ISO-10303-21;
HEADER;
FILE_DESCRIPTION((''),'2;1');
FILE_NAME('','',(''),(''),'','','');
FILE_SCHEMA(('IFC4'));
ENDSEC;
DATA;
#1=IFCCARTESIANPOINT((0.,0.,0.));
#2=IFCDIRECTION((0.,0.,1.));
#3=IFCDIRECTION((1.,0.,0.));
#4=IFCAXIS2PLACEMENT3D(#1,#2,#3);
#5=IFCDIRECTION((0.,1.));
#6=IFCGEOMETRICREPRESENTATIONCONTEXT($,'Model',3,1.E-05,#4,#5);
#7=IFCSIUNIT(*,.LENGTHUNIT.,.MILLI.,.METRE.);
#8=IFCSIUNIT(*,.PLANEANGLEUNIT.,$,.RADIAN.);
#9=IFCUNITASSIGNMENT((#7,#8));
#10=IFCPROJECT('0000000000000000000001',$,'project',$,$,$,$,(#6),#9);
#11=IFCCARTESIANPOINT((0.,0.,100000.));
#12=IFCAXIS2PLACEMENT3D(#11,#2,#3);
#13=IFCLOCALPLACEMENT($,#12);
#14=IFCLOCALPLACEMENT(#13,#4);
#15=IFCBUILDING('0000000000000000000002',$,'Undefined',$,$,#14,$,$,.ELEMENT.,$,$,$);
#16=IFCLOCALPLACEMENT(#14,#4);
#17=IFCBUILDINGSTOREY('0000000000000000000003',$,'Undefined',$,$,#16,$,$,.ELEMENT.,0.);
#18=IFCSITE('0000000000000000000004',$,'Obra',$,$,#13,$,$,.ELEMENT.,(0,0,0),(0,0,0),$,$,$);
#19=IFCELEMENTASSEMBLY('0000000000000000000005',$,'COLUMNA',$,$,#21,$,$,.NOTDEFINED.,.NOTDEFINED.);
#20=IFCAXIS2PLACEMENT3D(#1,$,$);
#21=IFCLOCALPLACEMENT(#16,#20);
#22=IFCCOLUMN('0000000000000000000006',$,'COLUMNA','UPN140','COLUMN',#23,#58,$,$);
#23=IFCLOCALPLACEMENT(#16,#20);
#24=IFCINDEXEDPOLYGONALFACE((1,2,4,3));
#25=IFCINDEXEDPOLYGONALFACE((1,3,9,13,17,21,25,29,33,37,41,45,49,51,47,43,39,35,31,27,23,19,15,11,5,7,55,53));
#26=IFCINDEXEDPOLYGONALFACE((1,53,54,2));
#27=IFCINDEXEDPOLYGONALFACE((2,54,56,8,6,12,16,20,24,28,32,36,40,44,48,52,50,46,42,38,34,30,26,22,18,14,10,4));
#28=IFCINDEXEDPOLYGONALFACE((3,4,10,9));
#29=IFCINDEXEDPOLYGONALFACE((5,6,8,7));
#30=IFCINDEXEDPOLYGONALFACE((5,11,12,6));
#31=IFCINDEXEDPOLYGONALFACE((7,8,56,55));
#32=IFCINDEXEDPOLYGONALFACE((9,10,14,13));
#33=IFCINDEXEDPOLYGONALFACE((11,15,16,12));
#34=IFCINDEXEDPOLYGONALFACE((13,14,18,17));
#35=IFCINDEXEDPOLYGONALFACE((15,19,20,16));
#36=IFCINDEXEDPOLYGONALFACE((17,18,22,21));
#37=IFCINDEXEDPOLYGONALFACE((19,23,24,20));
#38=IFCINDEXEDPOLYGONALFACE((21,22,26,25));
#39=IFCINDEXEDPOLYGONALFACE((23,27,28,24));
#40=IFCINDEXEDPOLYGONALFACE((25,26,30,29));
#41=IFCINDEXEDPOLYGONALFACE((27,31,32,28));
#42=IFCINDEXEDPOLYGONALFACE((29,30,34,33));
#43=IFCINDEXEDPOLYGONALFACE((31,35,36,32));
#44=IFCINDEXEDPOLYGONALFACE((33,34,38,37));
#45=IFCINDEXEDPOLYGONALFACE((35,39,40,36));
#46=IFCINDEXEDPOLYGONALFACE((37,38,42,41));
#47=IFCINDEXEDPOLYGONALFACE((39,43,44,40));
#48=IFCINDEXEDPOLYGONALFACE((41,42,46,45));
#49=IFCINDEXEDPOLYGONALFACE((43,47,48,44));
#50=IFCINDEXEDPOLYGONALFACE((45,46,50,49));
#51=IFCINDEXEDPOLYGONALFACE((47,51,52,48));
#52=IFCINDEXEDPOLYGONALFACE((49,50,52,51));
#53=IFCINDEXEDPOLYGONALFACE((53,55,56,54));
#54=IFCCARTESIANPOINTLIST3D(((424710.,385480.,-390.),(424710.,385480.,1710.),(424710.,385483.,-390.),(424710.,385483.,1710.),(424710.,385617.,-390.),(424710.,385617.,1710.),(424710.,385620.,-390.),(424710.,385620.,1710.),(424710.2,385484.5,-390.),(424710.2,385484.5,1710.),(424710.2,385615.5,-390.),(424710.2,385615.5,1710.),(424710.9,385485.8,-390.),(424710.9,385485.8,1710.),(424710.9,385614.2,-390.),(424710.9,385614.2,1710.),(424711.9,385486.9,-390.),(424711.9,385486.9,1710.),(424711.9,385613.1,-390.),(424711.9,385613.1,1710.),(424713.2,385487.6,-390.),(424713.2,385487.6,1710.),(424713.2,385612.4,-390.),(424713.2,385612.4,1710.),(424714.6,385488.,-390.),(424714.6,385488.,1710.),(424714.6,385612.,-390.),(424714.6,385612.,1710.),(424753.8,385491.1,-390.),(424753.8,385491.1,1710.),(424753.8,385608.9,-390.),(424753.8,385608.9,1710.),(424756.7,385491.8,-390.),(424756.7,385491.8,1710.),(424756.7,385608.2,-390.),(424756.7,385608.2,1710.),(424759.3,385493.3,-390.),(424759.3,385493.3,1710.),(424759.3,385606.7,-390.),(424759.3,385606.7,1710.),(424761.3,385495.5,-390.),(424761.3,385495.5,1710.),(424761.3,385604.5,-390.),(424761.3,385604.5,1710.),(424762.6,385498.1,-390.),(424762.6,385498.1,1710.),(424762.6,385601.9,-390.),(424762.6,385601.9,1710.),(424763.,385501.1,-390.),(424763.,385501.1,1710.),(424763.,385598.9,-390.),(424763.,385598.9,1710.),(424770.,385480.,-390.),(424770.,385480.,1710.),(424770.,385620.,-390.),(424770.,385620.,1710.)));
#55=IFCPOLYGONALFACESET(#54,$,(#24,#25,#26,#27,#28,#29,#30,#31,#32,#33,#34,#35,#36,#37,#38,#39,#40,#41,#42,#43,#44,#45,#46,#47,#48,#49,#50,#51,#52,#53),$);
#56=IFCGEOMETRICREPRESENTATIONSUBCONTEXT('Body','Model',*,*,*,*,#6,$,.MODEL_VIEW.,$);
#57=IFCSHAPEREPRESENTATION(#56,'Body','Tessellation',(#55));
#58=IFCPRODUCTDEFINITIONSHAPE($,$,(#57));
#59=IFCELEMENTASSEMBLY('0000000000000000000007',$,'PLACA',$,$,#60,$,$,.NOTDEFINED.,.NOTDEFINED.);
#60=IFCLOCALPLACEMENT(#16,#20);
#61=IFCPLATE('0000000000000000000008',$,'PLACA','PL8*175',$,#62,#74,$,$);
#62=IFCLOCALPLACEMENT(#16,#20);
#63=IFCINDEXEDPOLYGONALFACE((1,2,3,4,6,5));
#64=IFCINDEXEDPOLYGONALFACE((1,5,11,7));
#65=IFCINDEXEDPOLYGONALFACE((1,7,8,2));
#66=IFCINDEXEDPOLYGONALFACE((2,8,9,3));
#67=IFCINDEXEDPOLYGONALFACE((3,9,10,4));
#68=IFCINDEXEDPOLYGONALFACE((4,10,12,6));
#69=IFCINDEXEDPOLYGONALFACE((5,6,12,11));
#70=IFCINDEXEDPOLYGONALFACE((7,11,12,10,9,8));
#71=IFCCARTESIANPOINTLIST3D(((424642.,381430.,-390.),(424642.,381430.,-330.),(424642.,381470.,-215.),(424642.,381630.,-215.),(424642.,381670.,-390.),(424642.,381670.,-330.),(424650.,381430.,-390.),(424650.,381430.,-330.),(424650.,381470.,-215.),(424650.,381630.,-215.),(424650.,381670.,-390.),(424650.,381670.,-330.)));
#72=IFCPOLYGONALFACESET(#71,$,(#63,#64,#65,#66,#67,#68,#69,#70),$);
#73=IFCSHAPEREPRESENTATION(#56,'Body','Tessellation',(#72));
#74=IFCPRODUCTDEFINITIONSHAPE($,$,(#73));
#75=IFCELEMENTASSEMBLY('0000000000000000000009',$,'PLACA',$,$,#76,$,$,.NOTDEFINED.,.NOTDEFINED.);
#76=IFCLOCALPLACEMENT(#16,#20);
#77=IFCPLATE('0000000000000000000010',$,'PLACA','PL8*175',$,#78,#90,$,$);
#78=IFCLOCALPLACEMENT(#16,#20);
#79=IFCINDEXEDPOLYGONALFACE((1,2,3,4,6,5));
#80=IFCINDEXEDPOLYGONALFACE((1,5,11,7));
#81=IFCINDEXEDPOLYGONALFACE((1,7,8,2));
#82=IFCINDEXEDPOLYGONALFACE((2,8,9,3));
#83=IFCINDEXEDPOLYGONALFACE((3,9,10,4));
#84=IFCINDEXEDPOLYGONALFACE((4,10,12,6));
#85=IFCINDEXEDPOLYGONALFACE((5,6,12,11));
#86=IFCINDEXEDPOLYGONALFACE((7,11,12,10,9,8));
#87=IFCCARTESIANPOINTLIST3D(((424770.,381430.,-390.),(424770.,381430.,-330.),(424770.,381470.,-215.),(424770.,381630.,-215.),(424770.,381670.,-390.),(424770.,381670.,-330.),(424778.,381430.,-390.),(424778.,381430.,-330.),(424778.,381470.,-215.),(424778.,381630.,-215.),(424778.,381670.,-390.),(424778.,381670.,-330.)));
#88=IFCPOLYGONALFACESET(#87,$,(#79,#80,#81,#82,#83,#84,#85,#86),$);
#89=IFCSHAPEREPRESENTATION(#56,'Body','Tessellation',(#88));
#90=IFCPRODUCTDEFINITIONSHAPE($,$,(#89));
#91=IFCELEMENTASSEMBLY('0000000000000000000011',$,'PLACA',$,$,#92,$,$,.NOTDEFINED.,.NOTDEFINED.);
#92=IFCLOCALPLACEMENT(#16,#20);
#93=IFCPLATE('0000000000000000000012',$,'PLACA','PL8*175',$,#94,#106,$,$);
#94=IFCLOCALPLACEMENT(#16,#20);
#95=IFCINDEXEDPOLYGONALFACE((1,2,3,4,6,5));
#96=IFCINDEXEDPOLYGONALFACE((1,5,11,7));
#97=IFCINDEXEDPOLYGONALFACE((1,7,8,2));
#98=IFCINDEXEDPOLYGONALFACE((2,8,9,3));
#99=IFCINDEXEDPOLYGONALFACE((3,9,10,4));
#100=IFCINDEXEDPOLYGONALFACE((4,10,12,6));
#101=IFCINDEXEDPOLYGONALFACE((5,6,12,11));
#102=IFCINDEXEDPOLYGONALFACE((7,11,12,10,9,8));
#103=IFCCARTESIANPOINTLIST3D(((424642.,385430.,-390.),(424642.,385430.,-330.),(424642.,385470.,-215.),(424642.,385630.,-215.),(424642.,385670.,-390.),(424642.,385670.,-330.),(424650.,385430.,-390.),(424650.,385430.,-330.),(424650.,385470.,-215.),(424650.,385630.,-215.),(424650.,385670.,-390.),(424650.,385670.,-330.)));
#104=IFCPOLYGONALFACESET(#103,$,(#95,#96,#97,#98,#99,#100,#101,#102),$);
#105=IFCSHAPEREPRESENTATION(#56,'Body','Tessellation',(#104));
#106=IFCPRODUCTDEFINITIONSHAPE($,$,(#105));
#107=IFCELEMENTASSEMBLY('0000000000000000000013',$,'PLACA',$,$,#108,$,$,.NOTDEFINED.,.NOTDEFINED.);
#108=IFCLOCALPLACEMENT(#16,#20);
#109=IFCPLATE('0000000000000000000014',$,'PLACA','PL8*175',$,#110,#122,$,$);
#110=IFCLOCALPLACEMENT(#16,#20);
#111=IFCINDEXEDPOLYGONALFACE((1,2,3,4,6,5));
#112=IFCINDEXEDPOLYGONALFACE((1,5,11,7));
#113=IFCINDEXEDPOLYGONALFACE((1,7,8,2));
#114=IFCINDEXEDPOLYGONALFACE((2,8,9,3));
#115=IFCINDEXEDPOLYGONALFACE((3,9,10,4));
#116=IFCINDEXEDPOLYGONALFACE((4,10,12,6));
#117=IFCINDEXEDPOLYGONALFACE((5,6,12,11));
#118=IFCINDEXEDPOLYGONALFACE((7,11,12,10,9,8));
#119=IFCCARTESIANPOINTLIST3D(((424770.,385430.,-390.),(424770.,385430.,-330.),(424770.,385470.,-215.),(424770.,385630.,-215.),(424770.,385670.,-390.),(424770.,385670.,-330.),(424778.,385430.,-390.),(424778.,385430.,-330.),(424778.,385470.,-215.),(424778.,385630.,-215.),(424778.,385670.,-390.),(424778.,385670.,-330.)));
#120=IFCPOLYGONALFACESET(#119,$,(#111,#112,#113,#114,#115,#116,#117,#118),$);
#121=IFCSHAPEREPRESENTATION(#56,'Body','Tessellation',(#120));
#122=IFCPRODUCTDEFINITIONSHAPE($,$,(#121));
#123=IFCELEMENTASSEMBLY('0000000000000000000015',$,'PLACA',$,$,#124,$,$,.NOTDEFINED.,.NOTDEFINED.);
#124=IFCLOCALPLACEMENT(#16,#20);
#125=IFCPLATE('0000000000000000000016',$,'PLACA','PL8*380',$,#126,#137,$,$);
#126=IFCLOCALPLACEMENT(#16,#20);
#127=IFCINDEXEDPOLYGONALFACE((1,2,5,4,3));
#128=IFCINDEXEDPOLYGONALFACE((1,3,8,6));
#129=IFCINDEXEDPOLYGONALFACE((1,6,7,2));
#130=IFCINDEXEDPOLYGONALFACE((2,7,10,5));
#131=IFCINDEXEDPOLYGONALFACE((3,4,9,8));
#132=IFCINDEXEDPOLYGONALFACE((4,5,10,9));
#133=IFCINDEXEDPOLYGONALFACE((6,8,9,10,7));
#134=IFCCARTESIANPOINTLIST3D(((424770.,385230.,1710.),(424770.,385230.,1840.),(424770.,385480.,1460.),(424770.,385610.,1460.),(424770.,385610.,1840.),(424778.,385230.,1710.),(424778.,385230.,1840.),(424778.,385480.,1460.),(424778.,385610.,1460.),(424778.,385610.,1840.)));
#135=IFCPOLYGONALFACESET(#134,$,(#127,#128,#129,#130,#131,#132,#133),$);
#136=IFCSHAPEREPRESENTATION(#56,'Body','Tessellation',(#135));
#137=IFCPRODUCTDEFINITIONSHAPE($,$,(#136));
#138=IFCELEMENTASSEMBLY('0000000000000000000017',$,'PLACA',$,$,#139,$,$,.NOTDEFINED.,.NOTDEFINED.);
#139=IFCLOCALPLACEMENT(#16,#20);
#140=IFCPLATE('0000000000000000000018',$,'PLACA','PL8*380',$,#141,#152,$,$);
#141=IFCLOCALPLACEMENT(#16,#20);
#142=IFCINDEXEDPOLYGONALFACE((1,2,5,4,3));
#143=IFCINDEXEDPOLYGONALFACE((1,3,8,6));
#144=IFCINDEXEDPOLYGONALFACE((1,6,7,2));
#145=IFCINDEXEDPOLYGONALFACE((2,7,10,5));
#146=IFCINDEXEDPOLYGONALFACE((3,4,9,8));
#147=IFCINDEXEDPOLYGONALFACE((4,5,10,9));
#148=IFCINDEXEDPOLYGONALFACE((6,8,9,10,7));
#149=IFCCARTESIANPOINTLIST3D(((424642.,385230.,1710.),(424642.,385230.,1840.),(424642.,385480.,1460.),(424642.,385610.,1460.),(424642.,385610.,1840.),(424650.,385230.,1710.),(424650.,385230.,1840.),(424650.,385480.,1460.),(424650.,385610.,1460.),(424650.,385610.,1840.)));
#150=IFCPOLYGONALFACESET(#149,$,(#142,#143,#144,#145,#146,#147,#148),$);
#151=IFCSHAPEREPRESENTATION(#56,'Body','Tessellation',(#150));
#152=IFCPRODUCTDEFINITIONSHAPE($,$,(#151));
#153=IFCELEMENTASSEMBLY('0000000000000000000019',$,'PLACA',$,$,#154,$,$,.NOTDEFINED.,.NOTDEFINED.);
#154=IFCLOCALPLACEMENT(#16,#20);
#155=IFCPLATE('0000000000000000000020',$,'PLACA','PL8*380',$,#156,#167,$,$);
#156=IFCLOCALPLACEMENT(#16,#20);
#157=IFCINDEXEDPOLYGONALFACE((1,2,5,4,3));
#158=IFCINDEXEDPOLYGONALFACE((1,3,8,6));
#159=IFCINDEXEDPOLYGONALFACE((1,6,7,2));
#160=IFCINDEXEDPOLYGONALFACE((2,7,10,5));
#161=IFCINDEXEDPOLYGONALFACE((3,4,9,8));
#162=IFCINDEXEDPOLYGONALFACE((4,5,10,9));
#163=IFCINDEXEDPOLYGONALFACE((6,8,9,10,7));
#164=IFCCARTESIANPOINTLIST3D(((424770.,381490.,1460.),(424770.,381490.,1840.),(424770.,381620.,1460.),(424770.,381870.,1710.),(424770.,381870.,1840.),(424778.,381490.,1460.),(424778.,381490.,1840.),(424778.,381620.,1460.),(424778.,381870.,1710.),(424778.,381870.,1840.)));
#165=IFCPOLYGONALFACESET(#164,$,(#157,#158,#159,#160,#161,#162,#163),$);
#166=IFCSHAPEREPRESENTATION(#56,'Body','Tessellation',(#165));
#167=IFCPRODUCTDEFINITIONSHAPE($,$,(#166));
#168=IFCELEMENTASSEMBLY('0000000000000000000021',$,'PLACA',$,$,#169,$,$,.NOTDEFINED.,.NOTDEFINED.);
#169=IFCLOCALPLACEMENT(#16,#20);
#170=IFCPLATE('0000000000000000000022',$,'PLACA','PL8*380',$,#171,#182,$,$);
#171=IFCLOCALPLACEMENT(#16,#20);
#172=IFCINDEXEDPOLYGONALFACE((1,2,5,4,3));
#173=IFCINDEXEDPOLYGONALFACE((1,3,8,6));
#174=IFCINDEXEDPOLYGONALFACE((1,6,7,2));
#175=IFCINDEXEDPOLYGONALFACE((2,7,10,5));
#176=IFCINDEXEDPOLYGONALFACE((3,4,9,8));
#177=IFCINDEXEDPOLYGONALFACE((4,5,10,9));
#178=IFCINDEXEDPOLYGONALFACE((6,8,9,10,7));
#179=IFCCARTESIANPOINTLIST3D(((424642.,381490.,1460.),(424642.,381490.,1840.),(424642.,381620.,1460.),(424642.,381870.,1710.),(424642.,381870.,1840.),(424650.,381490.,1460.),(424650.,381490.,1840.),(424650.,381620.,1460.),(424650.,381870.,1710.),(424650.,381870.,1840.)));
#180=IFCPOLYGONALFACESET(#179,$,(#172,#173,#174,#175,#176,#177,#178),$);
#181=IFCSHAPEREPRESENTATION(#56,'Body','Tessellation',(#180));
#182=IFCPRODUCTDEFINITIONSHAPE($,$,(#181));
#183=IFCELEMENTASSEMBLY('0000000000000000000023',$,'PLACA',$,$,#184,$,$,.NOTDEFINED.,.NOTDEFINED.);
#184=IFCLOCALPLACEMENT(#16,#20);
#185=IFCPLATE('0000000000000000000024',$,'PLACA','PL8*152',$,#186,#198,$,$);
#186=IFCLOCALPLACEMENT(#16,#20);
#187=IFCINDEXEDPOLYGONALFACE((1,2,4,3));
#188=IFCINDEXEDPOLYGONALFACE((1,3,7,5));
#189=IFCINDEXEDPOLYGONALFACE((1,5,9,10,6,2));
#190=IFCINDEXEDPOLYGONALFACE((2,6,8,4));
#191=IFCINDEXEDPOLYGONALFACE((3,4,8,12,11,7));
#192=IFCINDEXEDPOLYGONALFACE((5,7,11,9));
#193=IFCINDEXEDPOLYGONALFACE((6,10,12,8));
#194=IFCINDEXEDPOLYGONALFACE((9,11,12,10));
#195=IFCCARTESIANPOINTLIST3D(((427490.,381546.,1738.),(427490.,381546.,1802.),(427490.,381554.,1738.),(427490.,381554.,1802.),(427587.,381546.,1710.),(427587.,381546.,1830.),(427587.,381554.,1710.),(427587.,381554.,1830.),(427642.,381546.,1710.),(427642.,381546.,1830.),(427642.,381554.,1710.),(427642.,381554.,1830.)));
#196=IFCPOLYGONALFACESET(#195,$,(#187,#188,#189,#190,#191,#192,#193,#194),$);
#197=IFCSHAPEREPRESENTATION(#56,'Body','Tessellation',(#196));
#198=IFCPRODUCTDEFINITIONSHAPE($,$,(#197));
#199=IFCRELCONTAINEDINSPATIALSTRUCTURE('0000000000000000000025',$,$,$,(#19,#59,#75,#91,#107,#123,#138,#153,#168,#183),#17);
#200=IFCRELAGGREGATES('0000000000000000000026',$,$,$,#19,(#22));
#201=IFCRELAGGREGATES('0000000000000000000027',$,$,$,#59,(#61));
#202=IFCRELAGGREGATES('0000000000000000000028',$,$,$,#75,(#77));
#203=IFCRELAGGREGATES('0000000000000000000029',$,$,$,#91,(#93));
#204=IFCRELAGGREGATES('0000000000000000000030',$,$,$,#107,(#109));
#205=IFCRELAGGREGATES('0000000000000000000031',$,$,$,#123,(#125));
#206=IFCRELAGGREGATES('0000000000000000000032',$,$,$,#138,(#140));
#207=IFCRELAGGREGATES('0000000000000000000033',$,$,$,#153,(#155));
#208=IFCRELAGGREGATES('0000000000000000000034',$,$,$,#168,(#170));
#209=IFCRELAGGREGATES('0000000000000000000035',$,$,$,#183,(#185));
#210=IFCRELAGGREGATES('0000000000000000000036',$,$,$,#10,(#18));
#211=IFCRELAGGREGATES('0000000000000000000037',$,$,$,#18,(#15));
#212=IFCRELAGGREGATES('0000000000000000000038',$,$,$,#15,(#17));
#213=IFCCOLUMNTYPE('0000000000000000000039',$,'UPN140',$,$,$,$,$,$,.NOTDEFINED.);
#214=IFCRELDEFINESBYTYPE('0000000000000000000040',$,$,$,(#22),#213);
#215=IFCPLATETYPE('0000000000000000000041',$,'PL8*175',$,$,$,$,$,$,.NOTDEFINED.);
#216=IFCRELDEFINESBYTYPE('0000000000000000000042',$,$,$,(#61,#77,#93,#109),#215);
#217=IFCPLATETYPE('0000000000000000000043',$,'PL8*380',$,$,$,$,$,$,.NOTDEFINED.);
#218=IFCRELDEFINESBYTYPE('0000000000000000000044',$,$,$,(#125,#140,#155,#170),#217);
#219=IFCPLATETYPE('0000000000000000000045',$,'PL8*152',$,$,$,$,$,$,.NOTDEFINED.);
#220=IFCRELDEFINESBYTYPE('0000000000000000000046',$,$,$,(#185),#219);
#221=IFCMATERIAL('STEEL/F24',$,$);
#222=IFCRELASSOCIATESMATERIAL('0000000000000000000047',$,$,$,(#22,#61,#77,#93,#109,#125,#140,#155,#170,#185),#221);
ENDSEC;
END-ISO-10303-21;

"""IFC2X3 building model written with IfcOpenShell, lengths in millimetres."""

from ifc_helpers import new_model, si_unit, direction, frame, origin_with_axes, origin_2d_with_axis, place, context, subcontext, project, spatial, polyline, u_section, outline, extrude, material, type_object, element, aggregate, save


model = new_model("IFC2X3")

# Units and contexts
model_context = context("Model", 3, precision=1e-05, world=origin_with_axes(), true_north=direction((0.0, 1.0)))
body_context = subcontext(model_context, "Body", "Model", "MODEL_VIEW")
ifc_project = project(units=[si_unit("LENGTHUNIT", "METRE", prefix="MILLI"), si_unit("PLANEANGLEUNIT", "RADIAN")], contexts=[model_context])

# Site, building, storey
site_placement = place(None, frame((0.0, 0.0, 100000.0), z_axis=(0.0, 0.0, 1.0), x_axis=(1.0, 0.0, 0.0)))
site = spatial("IfcSite", under=ifc_project, at=site_placement, Name="Obra", CompositionType="ELEMENT", RefLatitude=(0, 0, 0), RefLongitude=(0, 0, 0))
building_placement = place(site_placement, origin_with_axes())
building = spatial("IfcBuilding", under=site, at=building_placement, Name="Undefined", CompositionType="ELEMENT")
storey_placement = place(building_placement, origin_with_axes())
storey = spatial("IfcBuildingStorey", under=building, at=storey_placement, Name="Undefined", CompositionType="ELEMENT", Elevation=0.0)

# Element assembly, column
ifc_material_1 = material(Name="STEEL/F24")
column_type_1 = type_object("IfcColumnType", Name="UPN140", PredefinedType="NOTDEFINED")
assembly_1_placement = place(storey_placement, origin_with_axes())
assembly_1 = element("IfcElementAssembly", 1, at=assembly_1_placement, inside=storey, Name="COLUMNA", AssemblyPlace="NOTDEFINED", PredefinedType="NOTDEFINED")
column_1_placement = place(assembly_1_placement, frame((424740.0, 385550.0, -390.0), z_axis=(0.0, 0.0, 1.0), x_axis=(0.0, 1.0, 0.0)))
column_1 = element("IfcColumn", 2, at=column_1_placement, type_object=column_type_1, material=ifc_material_1, Name="COLUMNA", Description="UPN140", ObjectType="COLUMN", context=body_context, shape_type="SweptSolid", body=[
    extrude(u_section(Depth=140.0, FlangeWidth=60.0, WebThickness=7.0, FlangeThickness=10.0, FilletRadius=10.0, EdgeRadius=5.0, FlangeSlope=0.07983, at=origin_2d_with_axis()), frame((0.0, 0.0, 2100.0), z_axis=(0.0, 0.0, -1.0), x_axis=(0.0, 1.0, 0.0)), (0.0, 0.0, 1.0), 2100.0),
])
aggregate(assembly_1, [column_1])

# Element assemblies, plates
assembly_2_placement = place(storey_placement, origin_with_axes())
assembly_2 = element("IfcElementAssembly", 3, at=assembly_2_placement, inside=storey, Name="PLACA", AssemblyPlace="NOTDEFINED", PredefinedType="NOTDEFINED")
plate_type_1 = type_object("IfcPlateType", Name="PL8*175", PredefinedType="NOTDEFINED")
plate_1_placement = place(assembly_2_placement, frame((424646.0, 381630.0, -215.0), z_axis=(-1.0, 0.0, 0.0), x_axis=(0.0, 0.328521, -0.944497)))
plate_1 = element("IfcPlate", 4, at=plate_1_placement, type_object=plate_type_1, material=ifc_material_1, Name="PLACA", Description="PL8*175", context=body_context, shape_type="SweptSolid", body=[
    extrude(outline(polyline([(0.0, 0.0), (121.8, 0.0), (178.4, 19.7), (99.6, 246.4), (42.9, 226.7), (-52.6, 151.1), (0.0, 0.0)])), frame((0.0, 0.0, -4.0), z_axis=(0.0, 0.0, 1.0), x_axis=(1.0, 0.0, 0.0)), (0.0, 0.0, 1.0), 8.0),
])
aggregate(assembly_2, [plate_1])
assembly_3_placement = place(storey_placement, origin_with_axes())
assembly_3 = element("IfcElementAssembly", 5, at=assembly_3_placement, inside=storey, Name="PLACA", AssemblyPlace="NOTDEFINED", PredefinedType="NOTDEFINED")
plate_2_placement = place(assembly_3_placement, frame((424774.0, 381630.0, -215.0), z_axis=(-1.0, 0.0, 0.0), x_axis=(0.0, 0.328521, -0.944497)))
plate_2 = element("IfcPlate", 6, at=plate_2_placement, type_object=plate_type_1, material=ifc_material_1, Name="PLACA", Description="PL8*175", context=body_context, shape_type="SweptSolid", body=[
    extrude(outline(polyline([(0.0, 0.0), (121.8, 0.0), (178.4, 19.7), (99.6, 246.4), (42.9, 226.7), (-52.6, 151.1), (0.0, 0.0)])), frame((0.0, 0.0, -4.0), z_axis=(0.0, 0.0, 1.0), x_axis=(1.0, 0.0, 0.0)), (0.0, 0.0, 1.0), 8.0),
])
aggregate(assembly_3, [plate_2])
assembly_4_placement = place(storey_placement, origin_with_axes())
assembly_4 = element("IfcElementAssembly", 7, at=assembly_4_placement, inside=storey, Name="PLACA", AssemblyPlace="NOTDEFINED", PredefinedType="NOTDEFINED")
plate_3_placement = place(assembly_4_placement, frame((424646.0, 385630.0, -215.0), z_axis=(-1.0, 0.0, 0.0), x_axis=(0.0, 0.328521, -0.944497)))
plate_3 = element("IfcPlate", 8, at=plate_3_placement, type_object=plate_type_1, material=ifc_material_1, Name="PLACA", Description="PL8*175", context=body_context, shape_type="SweptSolid", body=[
    extrude(outline(polyline([(0.0, 0.0), (121.8, 0.0), (178.4, 19.7), (99.6, 246.4), (42.9, 226.7), (-52.6, 151.1), (0.0, 0.0)])), frame((0.0, 0.0, -4.0), z_axis=(0.0, 0.0, 1.0), x_axis=(1.0, 0.0, 0.0)), (0.0, 0.0, 1.0), 8.0),
])
aggregate(assembly_4, [plate_3])
assembly_5_placement = place(storey_placement, origin_with_axes())
assembly_5 = element("IfcElementAssembly", 9, at=assembly_5_placement, inside=storey, Name="PLACA", AssemblyPlace="NOTDEFINED", PredefinedType="NOTDEFINED")
plate_4_placement = place(assembly_5_placement, frame((424774.0, 385630.0, -215.0), z_axis=(-1.0, 0.0, 0.0), x_axis=(0.0, 0.328521, -0.944497)))
plate_4 = element("IfcPlate", 10, at=plate_4_placement, type_object=plate_type_1, material=ifc_material_1, Name="PLACA", Description="PL8*175", context=body_context, shape_type="SweptSolid", body=[
    extrude(outline(polyline([(0.0, 0.0), (121.8, 0.0), (178.4, 19.7), (99.6, 246.4), (42.9, 226.7), (-52.6, 151.1), (0.0, 0.0)])), frame((0.0, 0.0, -4.0), z_axis=(0.0, 0.0, 1.0), x_axis=(1.0, 0.0, 0.0)), (0.0, 0.0, 1.0), 8.0),
])
aggregate(assembly_5, [plate_4])
assembly_6_placement = place(storey_placement, origin_with_axes())
assembly_6 = element("IfcElementAssembly", 11, at=assembly_6_placement, inside=storey, Name="PLACA", AssemblyPlace="NOTDEFINED", PredefinedType="NOTDEFINED")
plate_type_2 = type_object("IfcPlateType", Name="PL8*380", PredefinedType="NOTDEFINED")
plate_5_placement = place(assembly_6_placement, frame((424774.0, 385230.0, 1840.0), z_axis=(-1.0, 0.0, 0.0), x_axis=(0.0, 1.0, 0.0)))
plate_5 = element("IfcPlate", 12, at=plate_5_placement, type_object=plate_type_2, material=ifc_material_1, Name="PLACA", Description="PL8*380", context=body_context, shape_type="SweptSolid", body=[
    extrude(outline(polyline([(0.0, 0.0), (380.0, 0.0), (380.0, 380.0), (250.0, 380.0), (0.0, 130.0), (0.0, 0.0)])), frame((0.0, 0.0, -4.0), z_axis=(0.0, 0.0, 1.0), x_axis=(1.0, 0.0, 0.0)), (0.0, 0.0, 1.0), 8.0),
])
aggregate(assembly_6, [plate_5])
assembly_7_placement = place(storey_placement, origin_with_axes())
assembly_7 = element("IfcElementAssembly", 13, at=assembly_7_placement, inside=storey, Name="PLACA", AssemblyPlace="NOTDEFINED", PredefinedType="NOTDEFINED")
plate_6_placement = place(assembly_7_placement, frame((424646.0, 385230.0, 1840.0), z_axis=(-1.0, 0.0, 0.0), x_axis=(0.0, 1.0, 0.0)))
plate_6 = element("IfcPlate", 14, at=plate_6_placement, type_object=plate_type_2, material=ifc_material_1, Name="PLACA", Description="PL8*380", context=body_context, shape_type="SweptSolid", body=[
    extrude(outline(polyline([(0.0, 0.0), (380.0, 0.0), (380.0, 380.0), (250.0, 380.0), (0.0, 130.0), (0.0, 0.0)])), frame((0.0, 0.0, -4.0), z_axis=(0.0, 0.0, 1.0), x_axis=(1.0, 0.0, 0.0)), (0.0, 0.0, 1.0), 8.0),
])
aggregate(assembly_7, [plate_6])
assembly_8_placement = place(storey_placement, origin_with_axes())
assembly_8 = element("IfcElementAssembly", 15, at=assembly_8_placement, inside=storey, Name="PLACA", AssemblyPlace="NOTDEFINED", PredefinedType="NOTDEFINED")
plate_7_placement = place(assembly_8_placement, frame((424774.0, 381870.0, 1840.0), z_axis=(1.0, 0.0, 0.0), x_axis=(0.0, -1.0, 0.0)))
plate_7 = element("IfcPlate", 16, at=plate_7_placement, type_object=plate_type_2, material=ifc_material_1, Name="PLACA", Description="PL8*380", context=body_context, shape_type="SweptSolid", body=[
    extrude(outline(polyline([(0.0, 0.0), (380.0, 0.0), (380.0, 380.0), (250.0, 380.0), (0.0, 130.0), (0.0, 0.0)])), frame((0.0, 0.0, -4.0), z_axis=(0.0, 0.0, 1.0), x_axis=(1.0, 0.0, 0.0)), (0.0, 0.0, 1.0), 8.0),
])
aggregate(assembly_8, [plate_7])
assembly_9_placement = place(storey_placement, origin_with_axes())
assembly_9 = element("IfcElementAssembly", 17, at=assembly_9_placement, inside=storey, Name="PLACA", AssemblyPlace="NOTDEFINED", PredefinedType="NOTDEFINED")
plate_8_placement = place(assembly_9_placement, frame((424646.0, 381870.0, 1840.0), z_axis=(1.0, 0.0, 0.0), x_axis=(0.0, -1.0, 0.0)))
plate_8 = element("IfcPlate", 18, at=plate_8_placement, type_object=plate_type_2, material=ifc_material_1, Name="PLACA", Description="PL8*380", context=body_context, shape_type="SweptSolid", body=[
    extrude(outline(polyline([(0.0, 0.0), (380.0, 0.0), (380.0, 380.0), (250.0, 380.0), (0.0, 130.0), (0.0, 0.0)])), frame((0.0, 0.0, -4.0), z_axis=(0.0, 0.0, 1.0), x_axis=(1.0, 0.0, 0.0)), (0.0, 0.0, 1.0), 8.0),
])
aggregate(assembly_9, [plate_8])
assembly_10_placement = place(storey_placement, origin_with_axes())
assembly_10 = element("IfcElementAssembly", 19, at=assembly_10_placement, inside=storey, Name="PLACA", AssemblyPlace="NOTDEFINED", PredefinedType="NOTDEFINED")
plate_type_3 = type_object("IfcPlateType", Name="PL8*152", PredefinedType="NOTDEFINED")
plate_9_placement = place(assembly_10_placement, frame((427587.0, 381550.0, 1830.0), z_axis=(0.0, 1.0, 0.0), x_axis=(1.0, 0.0, 0.0)))
plate_9 = element("IfcPlate", 20, at=plate_9_placement, type_object=plate_type_3, material=ifc_material_1, Name="PLACA", Description="PL8*152", context=body_context, shape_type="SweptSolid", body=[
    extrude(outline(polyline([(0.0, 0.0), (55.0, 0.0), (55.0, 120.0), (0.0, 120.0), (-97.0, 92.0), (-97.0, 28.0), (0.0, 0.0)])), frame((0.0, 0.0, -4.0), z_axis=(0.0, 0.0, 1.0), x_axis=(1.0, 0.0, 0.0)), (0.0, 0.0, 1.0), 8.0),
])
aggregate(assembly_10, [plate_9])

save(model, "model.ifc")
